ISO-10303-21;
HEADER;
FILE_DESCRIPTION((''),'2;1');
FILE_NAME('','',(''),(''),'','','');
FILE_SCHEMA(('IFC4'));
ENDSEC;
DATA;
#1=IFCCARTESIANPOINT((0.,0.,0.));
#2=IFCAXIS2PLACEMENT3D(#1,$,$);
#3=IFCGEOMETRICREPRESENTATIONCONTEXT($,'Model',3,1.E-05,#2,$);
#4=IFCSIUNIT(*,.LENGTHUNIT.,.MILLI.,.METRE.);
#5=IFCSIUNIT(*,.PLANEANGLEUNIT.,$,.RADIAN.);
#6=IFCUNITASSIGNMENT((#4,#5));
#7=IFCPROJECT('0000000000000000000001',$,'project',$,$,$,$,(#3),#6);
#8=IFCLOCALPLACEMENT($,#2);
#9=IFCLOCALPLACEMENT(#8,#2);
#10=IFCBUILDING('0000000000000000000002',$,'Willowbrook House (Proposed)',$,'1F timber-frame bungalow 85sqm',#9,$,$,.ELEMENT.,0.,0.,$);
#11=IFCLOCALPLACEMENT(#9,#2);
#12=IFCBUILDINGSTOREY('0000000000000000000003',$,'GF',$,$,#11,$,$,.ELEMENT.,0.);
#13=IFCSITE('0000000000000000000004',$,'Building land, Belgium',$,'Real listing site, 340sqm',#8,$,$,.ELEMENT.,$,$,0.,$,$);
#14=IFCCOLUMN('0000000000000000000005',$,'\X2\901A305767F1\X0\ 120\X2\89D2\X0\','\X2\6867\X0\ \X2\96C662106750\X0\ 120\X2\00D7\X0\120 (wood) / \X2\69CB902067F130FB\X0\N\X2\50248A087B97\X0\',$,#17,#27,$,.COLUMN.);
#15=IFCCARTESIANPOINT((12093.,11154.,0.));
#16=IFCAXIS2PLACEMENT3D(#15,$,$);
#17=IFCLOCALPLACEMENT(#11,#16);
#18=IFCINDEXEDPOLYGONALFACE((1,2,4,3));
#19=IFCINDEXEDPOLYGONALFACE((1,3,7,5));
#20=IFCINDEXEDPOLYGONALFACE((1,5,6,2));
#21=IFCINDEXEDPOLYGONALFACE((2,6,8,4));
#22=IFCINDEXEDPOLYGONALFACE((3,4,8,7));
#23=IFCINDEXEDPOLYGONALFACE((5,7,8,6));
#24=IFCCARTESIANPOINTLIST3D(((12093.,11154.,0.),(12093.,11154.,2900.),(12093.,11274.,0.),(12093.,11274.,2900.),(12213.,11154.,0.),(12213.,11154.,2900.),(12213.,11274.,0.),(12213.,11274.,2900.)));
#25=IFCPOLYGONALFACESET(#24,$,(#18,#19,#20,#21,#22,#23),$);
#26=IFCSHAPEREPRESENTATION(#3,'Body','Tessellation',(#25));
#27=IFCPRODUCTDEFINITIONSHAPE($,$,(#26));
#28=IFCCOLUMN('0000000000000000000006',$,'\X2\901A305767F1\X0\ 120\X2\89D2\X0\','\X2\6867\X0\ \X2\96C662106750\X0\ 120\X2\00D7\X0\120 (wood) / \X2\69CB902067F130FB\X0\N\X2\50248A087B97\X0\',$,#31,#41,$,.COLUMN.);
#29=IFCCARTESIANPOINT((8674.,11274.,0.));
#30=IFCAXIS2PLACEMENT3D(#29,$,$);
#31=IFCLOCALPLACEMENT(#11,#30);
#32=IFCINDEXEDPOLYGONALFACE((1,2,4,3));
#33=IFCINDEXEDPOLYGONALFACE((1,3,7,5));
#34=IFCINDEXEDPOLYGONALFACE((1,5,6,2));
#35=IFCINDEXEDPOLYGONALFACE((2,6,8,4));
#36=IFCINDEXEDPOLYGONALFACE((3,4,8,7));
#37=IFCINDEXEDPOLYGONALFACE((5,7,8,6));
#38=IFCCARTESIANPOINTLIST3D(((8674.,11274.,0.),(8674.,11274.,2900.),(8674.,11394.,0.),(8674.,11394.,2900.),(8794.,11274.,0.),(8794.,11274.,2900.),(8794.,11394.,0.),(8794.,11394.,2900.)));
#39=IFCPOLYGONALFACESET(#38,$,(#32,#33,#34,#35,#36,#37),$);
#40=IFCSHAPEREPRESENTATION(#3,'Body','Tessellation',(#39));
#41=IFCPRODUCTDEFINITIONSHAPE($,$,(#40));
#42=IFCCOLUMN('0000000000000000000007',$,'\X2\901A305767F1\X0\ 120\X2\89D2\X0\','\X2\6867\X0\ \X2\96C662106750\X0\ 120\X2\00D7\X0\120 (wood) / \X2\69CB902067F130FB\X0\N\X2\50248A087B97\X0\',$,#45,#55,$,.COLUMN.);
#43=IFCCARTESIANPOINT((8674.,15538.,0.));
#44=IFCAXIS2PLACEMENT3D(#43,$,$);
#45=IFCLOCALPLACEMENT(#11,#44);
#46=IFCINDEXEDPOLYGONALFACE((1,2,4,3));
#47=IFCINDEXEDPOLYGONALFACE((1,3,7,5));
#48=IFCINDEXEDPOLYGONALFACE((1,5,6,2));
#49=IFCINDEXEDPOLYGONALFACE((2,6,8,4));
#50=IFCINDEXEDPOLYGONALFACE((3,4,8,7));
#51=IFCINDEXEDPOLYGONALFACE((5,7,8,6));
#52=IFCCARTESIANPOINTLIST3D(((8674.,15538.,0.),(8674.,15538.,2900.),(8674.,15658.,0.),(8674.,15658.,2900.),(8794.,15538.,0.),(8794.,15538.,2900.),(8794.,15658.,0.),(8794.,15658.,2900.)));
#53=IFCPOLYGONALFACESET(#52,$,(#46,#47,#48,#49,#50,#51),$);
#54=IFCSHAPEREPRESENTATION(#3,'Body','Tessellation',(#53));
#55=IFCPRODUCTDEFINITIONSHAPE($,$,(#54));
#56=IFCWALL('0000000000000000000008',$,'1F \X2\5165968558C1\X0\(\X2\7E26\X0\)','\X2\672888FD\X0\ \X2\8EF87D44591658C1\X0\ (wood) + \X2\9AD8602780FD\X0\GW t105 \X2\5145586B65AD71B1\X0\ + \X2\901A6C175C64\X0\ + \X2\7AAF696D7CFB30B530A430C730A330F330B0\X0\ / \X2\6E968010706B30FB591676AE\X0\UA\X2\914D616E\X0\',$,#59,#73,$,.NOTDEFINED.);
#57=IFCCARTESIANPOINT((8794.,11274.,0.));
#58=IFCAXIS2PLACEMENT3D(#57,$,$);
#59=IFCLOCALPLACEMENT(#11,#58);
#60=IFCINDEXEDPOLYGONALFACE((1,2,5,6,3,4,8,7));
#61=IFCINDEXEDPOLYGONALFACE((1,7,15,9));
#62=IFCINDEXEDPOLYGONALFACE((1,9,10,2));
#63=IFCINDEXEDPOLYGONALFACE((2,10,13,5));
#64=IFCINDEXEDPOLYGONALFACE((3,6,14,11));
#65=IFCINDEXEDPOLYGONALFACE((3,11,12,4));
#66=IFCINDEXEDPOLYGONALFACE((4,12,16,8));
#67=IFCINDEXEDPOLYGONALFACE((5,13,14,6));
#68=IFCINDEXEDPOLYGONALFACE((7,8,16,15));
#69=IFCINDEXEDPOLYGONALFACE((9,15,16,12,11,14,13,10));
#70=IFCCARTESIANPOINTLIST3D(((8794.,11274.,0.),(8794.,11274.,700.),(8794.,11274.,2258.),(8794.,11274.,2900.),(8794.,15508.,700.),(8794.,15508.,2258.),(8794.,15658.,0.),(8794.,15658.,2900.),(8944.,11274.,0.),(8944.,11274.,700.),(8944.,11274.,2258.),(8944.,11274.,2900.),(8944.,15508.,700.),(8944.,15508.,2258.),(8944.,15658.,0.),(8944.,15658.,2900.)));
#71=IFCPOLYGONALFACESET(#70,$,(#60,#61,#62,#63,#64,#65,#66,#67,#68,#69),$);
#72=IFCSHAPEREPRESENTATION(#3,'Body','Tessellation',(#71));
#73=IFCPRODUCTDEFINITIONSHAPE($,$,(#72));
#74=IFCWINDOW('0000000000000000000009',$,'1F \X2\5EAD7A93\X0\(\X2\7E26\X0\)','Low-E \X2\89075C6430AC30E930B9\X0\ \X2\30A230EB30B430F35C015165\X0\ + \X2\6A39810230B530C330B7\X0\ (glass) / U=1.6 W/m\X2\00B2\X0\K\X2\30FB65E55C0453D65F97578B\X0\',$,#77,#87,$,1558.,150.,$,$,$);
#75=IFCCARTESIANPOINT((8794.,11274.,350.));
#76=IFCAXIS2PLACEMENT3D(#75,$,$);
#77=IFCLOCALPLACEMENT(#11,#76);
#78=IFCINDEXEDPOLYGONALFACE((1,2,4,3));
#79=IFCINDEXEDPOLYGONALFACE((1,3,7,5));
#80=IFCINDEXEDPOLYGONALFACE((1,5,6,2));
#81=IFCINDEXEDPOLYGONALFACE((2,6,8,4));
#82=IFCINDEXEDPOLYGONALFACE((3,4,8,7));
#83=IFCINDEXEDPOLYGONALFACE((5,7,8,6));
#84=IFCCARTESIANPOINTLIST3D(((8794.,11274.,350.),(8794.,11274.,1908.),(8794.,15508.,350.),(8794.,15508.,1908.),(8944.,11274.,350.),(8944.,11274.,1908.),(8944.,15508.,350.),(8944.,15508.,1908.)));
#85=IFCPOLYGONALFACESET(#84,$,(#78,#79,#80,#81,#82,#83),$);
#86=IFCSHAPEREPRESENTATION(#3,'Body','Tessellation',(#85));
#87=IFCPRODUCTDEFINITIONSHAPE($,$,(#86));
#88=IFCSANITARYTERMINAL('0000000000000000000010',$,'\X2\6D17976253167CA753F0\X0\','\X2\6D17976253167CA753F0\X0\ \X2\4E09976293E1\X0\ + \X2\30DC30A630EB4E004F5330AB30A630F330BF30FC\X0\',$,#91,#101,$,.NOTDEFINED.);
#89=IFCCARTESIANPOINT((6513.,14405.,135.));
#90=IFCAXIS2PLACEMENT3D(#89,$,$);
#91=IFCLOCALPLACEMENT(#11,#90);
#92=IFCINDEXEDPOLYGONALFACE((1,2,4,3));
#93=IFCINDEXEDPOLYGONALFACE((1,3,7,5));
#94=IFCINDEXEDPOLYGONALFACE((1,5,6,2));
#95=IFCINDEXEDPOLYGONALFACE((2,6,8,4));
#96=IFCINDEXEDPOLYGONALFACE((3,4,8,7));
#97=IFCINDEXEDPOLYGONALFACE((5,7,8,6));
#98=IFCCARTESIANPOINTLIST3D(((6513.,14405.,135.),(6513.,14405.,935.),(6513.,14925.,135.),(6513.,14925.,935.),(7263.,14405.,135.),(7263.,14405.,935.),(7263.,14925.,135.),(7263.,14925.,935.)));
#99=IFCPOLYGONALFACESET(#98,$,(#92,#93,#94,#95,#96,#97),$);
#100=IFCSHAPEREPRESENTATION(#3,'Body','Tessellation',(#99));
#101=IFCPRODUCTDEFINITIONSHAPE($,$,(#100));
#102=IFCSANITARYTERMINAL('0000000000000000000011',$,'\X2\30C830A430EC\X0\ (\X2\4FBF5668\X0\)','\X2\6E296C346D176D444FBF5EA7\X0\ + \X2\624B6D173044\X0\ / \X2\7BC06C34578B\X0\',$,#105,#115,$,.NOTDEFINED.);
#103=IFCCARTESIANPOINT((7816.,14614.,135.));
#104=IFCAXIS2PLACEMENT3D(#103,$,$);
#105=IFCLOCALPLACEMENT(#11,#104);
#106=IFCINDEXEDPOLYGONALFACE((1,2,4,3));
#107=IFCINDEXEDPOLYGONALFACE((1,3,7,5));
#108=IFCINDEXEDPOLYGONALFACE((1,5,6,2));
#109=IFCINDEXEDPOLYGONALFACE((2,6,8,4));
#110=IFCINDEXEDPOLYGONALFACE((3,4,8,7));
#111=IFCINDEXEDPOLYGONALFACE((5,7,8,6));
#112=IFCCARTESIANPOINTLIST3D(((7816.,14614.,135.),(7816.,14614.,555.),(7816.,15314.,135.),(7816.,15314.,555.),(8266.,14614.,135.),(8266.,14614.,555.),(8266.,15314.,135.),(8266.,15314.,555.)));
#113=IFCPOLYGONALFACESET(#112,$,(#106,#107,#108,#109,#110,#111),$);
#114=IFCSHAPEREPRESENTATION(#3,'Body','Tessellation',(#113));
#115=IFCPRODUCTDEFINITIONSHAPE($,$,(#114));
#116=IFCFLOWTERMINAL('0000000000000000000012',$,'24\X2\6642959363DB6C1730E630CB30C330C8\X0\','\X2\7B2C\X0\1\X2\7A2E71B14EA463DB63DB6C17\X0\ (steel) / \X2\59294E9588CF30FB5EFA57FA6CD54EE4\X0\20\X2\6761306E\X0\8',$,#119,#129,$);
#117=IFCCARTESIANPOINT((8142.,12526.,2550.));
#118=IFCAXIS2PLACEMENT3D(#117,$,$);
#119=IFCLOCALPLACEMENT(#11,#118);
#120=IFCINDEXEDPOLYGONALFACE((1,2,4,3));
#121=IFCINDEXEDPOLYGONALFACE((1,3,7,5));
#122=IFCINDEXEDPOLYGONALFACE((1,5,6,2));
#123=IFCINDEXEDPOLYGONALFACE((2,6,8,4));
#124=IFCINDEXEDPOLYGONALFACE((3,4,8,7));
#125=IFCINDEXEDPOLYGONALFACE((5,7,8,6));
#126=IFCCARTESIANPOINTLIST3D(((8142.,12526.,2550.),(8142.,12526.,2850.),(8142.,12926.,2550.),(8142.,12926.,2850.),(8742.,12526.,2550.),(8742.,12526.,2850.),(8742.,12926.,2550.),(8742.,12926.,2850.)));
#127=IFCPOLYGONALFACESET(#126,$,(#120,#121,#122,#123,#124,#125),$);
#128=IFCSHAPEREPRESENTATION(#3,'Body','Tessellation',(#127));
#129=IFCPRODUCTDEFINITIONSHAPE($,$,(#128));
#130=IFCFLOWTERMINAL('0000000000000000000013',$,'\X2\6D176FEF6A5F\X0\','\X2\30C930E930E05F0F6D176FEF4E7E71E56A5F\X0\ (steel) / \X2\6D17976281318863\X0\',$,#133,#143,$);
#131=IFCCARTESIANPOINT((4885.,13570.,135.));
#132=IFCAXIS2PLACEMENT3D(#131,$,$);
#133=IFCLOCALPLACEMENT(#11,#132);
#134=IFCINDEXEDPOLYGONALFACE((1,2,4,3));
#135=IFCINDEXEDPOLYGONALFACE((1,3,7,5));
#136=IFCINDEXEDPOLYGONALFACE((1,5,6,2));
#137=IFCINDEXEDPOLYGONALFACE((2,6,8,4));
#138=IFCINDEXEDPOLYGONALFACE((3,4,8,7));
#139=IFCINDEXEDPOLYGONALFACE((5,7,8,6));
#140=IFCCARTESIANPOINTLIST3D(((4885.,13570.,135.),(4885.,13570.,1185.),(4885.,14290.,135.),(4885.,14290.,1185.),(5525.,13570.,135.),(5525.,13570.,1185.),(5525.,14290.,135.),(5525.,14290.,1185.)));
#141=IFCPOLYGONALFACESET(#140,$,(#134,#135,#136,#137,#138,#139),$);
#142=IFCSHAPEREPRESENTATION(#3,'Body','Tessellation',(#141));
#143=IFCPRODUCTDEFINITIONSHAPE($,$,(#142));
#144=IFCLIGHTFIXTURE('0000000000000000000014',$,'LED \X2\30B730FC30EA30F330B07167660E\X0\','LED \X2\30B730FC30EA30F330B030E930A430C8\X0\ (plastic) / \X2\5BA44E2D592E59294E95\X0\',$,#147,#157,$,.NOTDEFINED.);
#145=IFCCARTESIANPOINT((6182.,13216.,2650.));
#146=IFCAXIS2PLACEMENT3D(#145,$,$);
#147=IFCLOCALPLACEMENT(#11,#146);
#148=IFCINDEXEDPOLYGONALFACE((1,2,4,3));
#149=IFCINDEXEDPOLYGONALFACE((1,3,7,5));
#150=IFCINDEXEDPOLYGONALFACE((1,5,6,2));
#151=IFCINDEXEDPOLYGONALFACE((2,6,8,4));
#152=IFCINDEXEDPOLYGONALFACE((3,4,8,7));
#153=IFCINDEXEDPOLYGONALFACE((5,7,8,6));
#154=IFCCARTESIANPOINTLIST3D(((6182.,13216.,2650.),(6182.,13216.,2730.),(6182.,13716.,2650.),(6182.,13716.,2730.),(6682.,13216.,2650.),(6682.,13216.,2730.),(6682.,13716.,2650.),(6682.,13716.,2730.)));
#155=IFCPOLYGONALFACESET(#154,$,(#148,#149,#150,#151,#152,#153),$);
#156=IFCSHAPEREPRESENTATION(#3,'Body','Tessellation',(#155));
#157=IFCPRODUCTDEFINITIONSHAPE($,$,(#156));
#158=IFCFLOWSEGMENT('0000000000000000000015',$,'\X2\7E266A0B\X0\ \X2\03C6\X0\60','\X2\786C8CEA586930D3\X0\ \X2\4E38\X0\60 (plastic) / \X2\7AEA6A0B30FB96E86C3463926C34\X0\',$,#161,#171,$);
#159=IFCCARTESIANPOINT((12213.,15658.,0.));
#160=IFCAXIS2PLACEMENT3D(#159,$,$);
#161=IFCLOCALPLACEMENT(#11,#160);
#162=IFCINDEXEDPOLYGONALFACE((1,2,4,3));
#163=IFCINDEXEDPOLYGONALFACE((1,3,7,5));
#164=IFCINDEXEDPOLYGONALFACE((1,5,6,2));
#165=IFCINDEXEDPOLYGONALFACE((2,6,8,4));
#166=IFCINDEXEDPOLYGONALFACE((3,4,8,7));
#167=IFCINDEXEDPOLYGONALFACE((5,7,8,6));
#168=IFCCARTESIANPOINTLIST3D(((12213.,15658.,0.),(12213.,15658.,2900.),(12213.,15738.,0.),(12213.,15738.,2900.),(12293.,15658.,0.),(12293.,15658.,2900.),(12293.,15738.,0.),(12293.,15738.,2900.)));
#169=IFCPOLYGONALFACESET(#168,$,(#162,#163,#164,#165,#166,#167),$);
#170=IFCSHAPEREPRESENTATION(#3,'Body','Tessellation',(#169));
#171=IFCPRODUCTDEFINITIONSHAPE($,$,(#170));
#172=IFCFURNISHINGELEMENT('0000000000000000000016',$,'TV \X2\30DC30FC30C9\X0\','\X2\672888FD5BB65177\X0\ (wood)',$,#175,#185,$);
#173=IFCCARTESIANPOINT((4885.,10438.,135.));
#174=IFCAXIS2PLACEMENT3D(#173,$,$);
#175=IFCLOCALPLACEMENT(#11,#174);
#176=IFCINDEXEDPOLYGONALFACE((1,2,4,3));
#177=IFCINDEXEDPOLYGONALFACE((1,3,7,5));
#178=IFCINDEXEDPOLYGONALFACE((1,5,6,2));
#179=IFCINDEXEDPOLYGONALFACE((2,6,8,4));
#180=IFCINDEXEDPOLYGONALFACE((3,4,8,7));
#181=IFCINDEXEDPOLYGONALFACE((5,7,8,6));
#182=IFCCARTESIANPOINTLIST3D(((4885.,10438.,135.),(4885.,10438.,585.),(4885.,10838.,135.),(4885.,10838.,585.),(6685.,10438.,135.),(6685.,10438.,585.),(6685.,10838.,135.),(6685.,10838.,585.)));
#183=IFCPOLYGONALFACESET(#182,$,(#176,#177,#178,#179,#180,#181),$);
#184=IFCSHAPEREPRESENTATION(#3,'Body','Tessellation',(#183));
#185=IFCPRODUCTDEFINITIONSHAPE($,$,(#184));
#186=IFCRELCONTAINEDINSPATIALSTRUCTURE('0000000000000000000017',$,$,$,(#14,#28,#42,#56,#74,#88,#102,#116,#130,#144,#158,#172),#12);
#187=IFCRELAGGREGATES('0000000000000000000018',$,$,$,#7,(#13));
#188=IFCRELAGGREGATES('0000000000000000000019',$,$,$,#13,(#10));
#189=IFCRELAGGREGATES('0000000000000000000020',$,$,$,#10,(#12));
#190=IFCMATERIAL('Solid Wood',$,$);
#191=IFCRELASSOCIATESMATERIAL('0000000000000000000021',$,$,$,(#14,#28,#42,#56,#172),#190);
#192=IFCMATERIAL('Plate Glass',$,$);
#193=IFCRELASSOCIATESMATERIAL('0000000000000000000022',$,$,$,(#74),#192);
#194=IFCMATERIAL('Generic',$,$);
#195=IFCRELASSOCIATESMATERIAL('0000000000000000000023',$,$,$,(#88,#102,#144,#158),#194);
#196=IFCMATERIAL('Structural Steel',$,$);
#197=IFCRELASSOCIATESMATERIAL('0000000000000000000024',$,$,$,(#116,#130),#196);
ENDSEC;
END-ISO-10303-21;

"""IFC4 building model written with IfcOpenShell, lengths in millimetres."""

from ifc_helpers import new_model, si_unit, frame, frame_2d, origin, place, context, project, spatial, rectangle, extrude, material, element, fill, save


model = new_model("IFC4")

# Units and contexts
model_context = context("Model", 3, precision=1e-05, world=origin())
ifc_project = project(units=[si_unit("LENGTHUNIT", "METRE", prefix="MILLI"), si_unit("PLANEANGLEUNIT", "RADIAN")], contexts=[model_context])

# Site, building, storey
site_placement = place(None, origin())
site = spatial("IfcSite", under=ifc_project, at=site_placement, Name="Building land, Belgium", ObjectType="Real listing site, 340sqm", CompositionType="ELEMENT", RefElevation=0.0)
building_placement = place(site_placement, origin())
building = spatial("IfcBuilding", under=site, at=building_placement, Name="Willowbrook House (Proposed)", ObjectType="1F timber-frame bungalow 85sqm", CompositionType="ELEMENT", ElevationOfRefHeight=0.0, ElevationOfTerrain=0.0)
storey_placement = place(building_placement, origin())
storey = spatial("IfcBuildingStorey", under=building, at=storey_placement, Name="GF", CompositionType="ELEMENT", Elevation=0.0)

# Columns
ifc_material_1 = material(Name="Solid Wood")
column_1_placement = place(storey_placement, frame((12093.0, 11154.0, 0.0)))
element("IfcColumn", 1, at=column_1_placement, inside=storey, material=ifc_material_1, Name="通し柱 120角", Description="桧 集成材 120×120 (wood) / 構造柱・N値計算", PredefinedType="COLUMN", context=model_context, shape_type="SweptSolid", body=[
    extrude(rectangle(XDim=120.0, YDim=120.0, at=frame_2d((60.0, 60.0))), frame((12093.0, 11154.0, 0.0)), (0.0, 0.0, 1.0), 2900.0),
])
column_2_placement = place(storey_placement, frame((8674.0, 11274.0, 0.0)))
element("IfcColumn", 2, at=column_2_placement, inside=storey, material=ifc_material_1, Name="通し柱 120角", Description="桧 集成材 120×120 (wood) / 構造柱・N値計算", PredefinedType="COLUMN", context=model_context, shape_type="SweptSolid", body=[
    extrude(rectangle(XDim=120.0, YDim=120.0, at=frame_2d((60.0, 60.0))), frame((8674.0, 11274.0, 0.0)), (0.0, 0.0, 1.0), 2900.0),
])
column_3_placement = place(storey_placement, frame((8674.0, 15538.0, 0.0)))
element("IfcColumn", 3, at=column_3_placement, inside=storey, material=ifc_material_1, Name="通し柱 120角", Description="桧 集成材 120×120 (wood) / 構造柱・N値計算", PredefinedType="COLUMN", context=model_context, shape_type="SweptSolid", body=[
    extrude(rectangle(XDim=120.0, YDim=120.0, at=frame_2d((60.0, 60.0))), frame((8674.0, 15538.0, 0.0)), (0.0, 0.0, 1.0), 2900.0),
])

# Wall, opening, window
wall_1_placement = place(storey_placement, frame((8794.0, 11274.0, 0.0)))
wall_1 = element("IfcWall", 4, at=wall_1_placement, inside=storey, material=ifc_material_1, Name="1F 入隅壁(縦)", Description="木製 軸組外壁 (wood) + 高性能GW t105 充填断熱 + 通気層 + 窯業系サイディング / 準耐火・外皮UA配慮", PredefinedType="NOTDEFINED", context=model_context, shape_type="SweptSolid", body=[
    extrude(rectangle(XDim=150.0, YDim=4384.0, at=frame_2d((75.0, 2192.0))), frame((8794.0, 11274.0, 0.0)), (0.0, 0.0, 1.0), 2900.0),
])
opening_placement = place(storey_placement, frame((8794.0, 11274.0, 350.0)))
opening = element("IfcOpeningElement", 5, at=opening_placement, cuts=wall_1, PredefinedType="NOTDEFINED", context=model_context, shape_type="SweptSolid", body=[
    extrude(rectangle(XDim=150.0, YDim=4234.0, at=frame_2d((75.0, 2117.0))), frame((8794.0, 11274.0, 350.0)), (0.0, 0.0, 1.0), 1558.0),
])
ifc_material_2 = material(Name="Plate Glass")
window_placement = place(storey_placement, frame((8794.0, 11274.0, 350.0)))
window = element("IfcWindow", 6, at=window_placement, inside=storey, material=ifc_material_2, Name="1F 庭窓(縦)", Description="Low-E 複層ガラス アルゴン封入 + 樹脂サッシ (glass) / U=1.6 W/m²K・日射取得型", OverallHeight=1558.0, OverallWidth=150.0, context=model_context, shape_type="SweptSolid", body=[
    extrude(rectangle(XDim=150.0, YDim=4234.0, at=frame_2d((75.0, 2117.0))), frame((8794.0, 11274.0, 350.0)), (0.0, 0.0, 1.0), 1558.0),
])
fill(opening, window)

# Sanitary terminals
ifc_material_3 = material(Name="Generic")
sanitary_terminal_1_placement = place(storey_placement, frame((6513.0, 14405.0, 135.0)))
element("IfcSanitaryTerminal", 7, at=sanitary_terminal_1_placement, inside=storey, material=ifc_material_3, Name="洗面化粧台", Description="洗面化粧台 三面鏡 + ボウル一体カウンター", PredefinedType="NOTDEFINED", context=model_context, shape_type="SweptSolid", body=[
    extrude(rectangle(XDim=750.0, YDim=520.0, at=frame_2d((375.0, 260.0))), frame((6513.0, 14405.0, 135.0)), (0.0, 0.0, 1.0), 800.0),
])
sanitary_terminal_2_placement = place(storey_placement, frame((7816.0, 14614.0, 135.0)))
element("IfcSanitaryTerminal", 8, at=sanitary_terminal_2_placement, inside=storey, material=ifc_material_3, Name="トイレ (便器)", Description="温水洗浄便座 + 手洗い / 節水型", PredefinedType="NOTDEFINED", context=model_context, shape_type="SweptSolid", body=[
    extrude(rectangle(XDim=450.0, YDim=700.0, at=frame_2d((225.0, 350.0))), frame((7816.0, 14614.0, 135.0)), (0.0, 0.0, 1.0), 420.0),
])

# Flow terminals
ifc_material_4 = material(Name="Structural Steel")
flow_terminal_1_placement = place(storey_placement, frame((8142.0, 12526.0, 2550.0)))
element("IfcFlowTerminal", 9, at=flow_terminal_1_placement, inside=storey, material=ifc_material_4, Name="24時間換気ユニット", Description="第1種熱交換換気 (steel) / 天井裏・建基法令20条の8", context=model_context, shape_type="SweptSolid", body=[
    extrude(rectangle(XDim=600.0, YDim=400.0, at=frame_2d((300.0, 200.0))), frame((8142.0, 12526.0, 2550.0)), (0.0, 0.0, 1.0), 300.0),
])
flow_terminal_2_placement = place(storey_placement, frame((4885.0, 13570.0, 135.0)))
element("IfcFlowTerminal", 10, at=flow_terminal_2_placement, inside=storey, material=ifc_material_4, Name="洗濯機", Description="ドラム式洗濯乾燥機 (steel) / 洗面脱衣", context=model_context, shape_type="SweptSolid", body=[
    extrude(rectangle(XDim=640.0, YDim=720.0, at=frame_2d((320.0, 360.0))), frame((4885.0, 13570.0, 135.0)), (0.0, 0.0, 1.0), 1050.0),
])

# Light fixture
light_fixture_placement = place(storey_placement, frame((6182.0, 13216.0, 2650.0)))
element("IfcLightFixture", 11, at=light_fixture_placement, inside=storey, material=ifc_material_3, Name="LED シーリング照明", Description="LED シーリングライト (plastic) / 室中央天井", PredefinedType="NOTDEFINED", context=model_context, shape_type="SweptSolid", body=[
    extrude(rectangle(XDim=500.0, YDim=500.0, at=frame_2d((250.0, 250.0))), frame((6182.0, 13216.0, 2650.0)), (0.0, 0.0, 1.0), 80.0),
])

# Flow segment
flow_segment_placement = place(storey_placement, frame((12213.0, 15658.0, 0.0)))
element("IfcFlowSegment", 12, at=flow_segment_placement, inside=storey, material=ifc_material_3, Name="縦樋 φ60", Description="硬質塩ビ 丸60 (plastic) / 竪樋・雨水排水", context=model_context, shape_type="SweptSolid", body=[
    extrude(rectangle(XDim=80.0, YDim=80.0, at=frame_2d((40.0, 40.0))), frame((12213.0, 15658.0, 0.0)), (0.0, 0.0, 1.0), 2900.0),
])

# Furnishing element
furnishing_placement = place(storey_placement, frame((4885.0, 10438.0, 135.0)))
element("IfcFurnishingElement", 13, at=furnishing_placement, inside=storey, material=ifc_material_1, Name="TV ボード", Description="木製家具 (wood)", context=model_context, shape_type="SweptSolid", body=[
    extrude(rectangle(XDim=1800.0, YDim=400.0, at=frame_2d((900.0, 200.0))), frame((4885.0, 10438.0, 135.0)), (0.0, 0.0, 1.0), 450.0),
])

save(model, "model.ifc")
